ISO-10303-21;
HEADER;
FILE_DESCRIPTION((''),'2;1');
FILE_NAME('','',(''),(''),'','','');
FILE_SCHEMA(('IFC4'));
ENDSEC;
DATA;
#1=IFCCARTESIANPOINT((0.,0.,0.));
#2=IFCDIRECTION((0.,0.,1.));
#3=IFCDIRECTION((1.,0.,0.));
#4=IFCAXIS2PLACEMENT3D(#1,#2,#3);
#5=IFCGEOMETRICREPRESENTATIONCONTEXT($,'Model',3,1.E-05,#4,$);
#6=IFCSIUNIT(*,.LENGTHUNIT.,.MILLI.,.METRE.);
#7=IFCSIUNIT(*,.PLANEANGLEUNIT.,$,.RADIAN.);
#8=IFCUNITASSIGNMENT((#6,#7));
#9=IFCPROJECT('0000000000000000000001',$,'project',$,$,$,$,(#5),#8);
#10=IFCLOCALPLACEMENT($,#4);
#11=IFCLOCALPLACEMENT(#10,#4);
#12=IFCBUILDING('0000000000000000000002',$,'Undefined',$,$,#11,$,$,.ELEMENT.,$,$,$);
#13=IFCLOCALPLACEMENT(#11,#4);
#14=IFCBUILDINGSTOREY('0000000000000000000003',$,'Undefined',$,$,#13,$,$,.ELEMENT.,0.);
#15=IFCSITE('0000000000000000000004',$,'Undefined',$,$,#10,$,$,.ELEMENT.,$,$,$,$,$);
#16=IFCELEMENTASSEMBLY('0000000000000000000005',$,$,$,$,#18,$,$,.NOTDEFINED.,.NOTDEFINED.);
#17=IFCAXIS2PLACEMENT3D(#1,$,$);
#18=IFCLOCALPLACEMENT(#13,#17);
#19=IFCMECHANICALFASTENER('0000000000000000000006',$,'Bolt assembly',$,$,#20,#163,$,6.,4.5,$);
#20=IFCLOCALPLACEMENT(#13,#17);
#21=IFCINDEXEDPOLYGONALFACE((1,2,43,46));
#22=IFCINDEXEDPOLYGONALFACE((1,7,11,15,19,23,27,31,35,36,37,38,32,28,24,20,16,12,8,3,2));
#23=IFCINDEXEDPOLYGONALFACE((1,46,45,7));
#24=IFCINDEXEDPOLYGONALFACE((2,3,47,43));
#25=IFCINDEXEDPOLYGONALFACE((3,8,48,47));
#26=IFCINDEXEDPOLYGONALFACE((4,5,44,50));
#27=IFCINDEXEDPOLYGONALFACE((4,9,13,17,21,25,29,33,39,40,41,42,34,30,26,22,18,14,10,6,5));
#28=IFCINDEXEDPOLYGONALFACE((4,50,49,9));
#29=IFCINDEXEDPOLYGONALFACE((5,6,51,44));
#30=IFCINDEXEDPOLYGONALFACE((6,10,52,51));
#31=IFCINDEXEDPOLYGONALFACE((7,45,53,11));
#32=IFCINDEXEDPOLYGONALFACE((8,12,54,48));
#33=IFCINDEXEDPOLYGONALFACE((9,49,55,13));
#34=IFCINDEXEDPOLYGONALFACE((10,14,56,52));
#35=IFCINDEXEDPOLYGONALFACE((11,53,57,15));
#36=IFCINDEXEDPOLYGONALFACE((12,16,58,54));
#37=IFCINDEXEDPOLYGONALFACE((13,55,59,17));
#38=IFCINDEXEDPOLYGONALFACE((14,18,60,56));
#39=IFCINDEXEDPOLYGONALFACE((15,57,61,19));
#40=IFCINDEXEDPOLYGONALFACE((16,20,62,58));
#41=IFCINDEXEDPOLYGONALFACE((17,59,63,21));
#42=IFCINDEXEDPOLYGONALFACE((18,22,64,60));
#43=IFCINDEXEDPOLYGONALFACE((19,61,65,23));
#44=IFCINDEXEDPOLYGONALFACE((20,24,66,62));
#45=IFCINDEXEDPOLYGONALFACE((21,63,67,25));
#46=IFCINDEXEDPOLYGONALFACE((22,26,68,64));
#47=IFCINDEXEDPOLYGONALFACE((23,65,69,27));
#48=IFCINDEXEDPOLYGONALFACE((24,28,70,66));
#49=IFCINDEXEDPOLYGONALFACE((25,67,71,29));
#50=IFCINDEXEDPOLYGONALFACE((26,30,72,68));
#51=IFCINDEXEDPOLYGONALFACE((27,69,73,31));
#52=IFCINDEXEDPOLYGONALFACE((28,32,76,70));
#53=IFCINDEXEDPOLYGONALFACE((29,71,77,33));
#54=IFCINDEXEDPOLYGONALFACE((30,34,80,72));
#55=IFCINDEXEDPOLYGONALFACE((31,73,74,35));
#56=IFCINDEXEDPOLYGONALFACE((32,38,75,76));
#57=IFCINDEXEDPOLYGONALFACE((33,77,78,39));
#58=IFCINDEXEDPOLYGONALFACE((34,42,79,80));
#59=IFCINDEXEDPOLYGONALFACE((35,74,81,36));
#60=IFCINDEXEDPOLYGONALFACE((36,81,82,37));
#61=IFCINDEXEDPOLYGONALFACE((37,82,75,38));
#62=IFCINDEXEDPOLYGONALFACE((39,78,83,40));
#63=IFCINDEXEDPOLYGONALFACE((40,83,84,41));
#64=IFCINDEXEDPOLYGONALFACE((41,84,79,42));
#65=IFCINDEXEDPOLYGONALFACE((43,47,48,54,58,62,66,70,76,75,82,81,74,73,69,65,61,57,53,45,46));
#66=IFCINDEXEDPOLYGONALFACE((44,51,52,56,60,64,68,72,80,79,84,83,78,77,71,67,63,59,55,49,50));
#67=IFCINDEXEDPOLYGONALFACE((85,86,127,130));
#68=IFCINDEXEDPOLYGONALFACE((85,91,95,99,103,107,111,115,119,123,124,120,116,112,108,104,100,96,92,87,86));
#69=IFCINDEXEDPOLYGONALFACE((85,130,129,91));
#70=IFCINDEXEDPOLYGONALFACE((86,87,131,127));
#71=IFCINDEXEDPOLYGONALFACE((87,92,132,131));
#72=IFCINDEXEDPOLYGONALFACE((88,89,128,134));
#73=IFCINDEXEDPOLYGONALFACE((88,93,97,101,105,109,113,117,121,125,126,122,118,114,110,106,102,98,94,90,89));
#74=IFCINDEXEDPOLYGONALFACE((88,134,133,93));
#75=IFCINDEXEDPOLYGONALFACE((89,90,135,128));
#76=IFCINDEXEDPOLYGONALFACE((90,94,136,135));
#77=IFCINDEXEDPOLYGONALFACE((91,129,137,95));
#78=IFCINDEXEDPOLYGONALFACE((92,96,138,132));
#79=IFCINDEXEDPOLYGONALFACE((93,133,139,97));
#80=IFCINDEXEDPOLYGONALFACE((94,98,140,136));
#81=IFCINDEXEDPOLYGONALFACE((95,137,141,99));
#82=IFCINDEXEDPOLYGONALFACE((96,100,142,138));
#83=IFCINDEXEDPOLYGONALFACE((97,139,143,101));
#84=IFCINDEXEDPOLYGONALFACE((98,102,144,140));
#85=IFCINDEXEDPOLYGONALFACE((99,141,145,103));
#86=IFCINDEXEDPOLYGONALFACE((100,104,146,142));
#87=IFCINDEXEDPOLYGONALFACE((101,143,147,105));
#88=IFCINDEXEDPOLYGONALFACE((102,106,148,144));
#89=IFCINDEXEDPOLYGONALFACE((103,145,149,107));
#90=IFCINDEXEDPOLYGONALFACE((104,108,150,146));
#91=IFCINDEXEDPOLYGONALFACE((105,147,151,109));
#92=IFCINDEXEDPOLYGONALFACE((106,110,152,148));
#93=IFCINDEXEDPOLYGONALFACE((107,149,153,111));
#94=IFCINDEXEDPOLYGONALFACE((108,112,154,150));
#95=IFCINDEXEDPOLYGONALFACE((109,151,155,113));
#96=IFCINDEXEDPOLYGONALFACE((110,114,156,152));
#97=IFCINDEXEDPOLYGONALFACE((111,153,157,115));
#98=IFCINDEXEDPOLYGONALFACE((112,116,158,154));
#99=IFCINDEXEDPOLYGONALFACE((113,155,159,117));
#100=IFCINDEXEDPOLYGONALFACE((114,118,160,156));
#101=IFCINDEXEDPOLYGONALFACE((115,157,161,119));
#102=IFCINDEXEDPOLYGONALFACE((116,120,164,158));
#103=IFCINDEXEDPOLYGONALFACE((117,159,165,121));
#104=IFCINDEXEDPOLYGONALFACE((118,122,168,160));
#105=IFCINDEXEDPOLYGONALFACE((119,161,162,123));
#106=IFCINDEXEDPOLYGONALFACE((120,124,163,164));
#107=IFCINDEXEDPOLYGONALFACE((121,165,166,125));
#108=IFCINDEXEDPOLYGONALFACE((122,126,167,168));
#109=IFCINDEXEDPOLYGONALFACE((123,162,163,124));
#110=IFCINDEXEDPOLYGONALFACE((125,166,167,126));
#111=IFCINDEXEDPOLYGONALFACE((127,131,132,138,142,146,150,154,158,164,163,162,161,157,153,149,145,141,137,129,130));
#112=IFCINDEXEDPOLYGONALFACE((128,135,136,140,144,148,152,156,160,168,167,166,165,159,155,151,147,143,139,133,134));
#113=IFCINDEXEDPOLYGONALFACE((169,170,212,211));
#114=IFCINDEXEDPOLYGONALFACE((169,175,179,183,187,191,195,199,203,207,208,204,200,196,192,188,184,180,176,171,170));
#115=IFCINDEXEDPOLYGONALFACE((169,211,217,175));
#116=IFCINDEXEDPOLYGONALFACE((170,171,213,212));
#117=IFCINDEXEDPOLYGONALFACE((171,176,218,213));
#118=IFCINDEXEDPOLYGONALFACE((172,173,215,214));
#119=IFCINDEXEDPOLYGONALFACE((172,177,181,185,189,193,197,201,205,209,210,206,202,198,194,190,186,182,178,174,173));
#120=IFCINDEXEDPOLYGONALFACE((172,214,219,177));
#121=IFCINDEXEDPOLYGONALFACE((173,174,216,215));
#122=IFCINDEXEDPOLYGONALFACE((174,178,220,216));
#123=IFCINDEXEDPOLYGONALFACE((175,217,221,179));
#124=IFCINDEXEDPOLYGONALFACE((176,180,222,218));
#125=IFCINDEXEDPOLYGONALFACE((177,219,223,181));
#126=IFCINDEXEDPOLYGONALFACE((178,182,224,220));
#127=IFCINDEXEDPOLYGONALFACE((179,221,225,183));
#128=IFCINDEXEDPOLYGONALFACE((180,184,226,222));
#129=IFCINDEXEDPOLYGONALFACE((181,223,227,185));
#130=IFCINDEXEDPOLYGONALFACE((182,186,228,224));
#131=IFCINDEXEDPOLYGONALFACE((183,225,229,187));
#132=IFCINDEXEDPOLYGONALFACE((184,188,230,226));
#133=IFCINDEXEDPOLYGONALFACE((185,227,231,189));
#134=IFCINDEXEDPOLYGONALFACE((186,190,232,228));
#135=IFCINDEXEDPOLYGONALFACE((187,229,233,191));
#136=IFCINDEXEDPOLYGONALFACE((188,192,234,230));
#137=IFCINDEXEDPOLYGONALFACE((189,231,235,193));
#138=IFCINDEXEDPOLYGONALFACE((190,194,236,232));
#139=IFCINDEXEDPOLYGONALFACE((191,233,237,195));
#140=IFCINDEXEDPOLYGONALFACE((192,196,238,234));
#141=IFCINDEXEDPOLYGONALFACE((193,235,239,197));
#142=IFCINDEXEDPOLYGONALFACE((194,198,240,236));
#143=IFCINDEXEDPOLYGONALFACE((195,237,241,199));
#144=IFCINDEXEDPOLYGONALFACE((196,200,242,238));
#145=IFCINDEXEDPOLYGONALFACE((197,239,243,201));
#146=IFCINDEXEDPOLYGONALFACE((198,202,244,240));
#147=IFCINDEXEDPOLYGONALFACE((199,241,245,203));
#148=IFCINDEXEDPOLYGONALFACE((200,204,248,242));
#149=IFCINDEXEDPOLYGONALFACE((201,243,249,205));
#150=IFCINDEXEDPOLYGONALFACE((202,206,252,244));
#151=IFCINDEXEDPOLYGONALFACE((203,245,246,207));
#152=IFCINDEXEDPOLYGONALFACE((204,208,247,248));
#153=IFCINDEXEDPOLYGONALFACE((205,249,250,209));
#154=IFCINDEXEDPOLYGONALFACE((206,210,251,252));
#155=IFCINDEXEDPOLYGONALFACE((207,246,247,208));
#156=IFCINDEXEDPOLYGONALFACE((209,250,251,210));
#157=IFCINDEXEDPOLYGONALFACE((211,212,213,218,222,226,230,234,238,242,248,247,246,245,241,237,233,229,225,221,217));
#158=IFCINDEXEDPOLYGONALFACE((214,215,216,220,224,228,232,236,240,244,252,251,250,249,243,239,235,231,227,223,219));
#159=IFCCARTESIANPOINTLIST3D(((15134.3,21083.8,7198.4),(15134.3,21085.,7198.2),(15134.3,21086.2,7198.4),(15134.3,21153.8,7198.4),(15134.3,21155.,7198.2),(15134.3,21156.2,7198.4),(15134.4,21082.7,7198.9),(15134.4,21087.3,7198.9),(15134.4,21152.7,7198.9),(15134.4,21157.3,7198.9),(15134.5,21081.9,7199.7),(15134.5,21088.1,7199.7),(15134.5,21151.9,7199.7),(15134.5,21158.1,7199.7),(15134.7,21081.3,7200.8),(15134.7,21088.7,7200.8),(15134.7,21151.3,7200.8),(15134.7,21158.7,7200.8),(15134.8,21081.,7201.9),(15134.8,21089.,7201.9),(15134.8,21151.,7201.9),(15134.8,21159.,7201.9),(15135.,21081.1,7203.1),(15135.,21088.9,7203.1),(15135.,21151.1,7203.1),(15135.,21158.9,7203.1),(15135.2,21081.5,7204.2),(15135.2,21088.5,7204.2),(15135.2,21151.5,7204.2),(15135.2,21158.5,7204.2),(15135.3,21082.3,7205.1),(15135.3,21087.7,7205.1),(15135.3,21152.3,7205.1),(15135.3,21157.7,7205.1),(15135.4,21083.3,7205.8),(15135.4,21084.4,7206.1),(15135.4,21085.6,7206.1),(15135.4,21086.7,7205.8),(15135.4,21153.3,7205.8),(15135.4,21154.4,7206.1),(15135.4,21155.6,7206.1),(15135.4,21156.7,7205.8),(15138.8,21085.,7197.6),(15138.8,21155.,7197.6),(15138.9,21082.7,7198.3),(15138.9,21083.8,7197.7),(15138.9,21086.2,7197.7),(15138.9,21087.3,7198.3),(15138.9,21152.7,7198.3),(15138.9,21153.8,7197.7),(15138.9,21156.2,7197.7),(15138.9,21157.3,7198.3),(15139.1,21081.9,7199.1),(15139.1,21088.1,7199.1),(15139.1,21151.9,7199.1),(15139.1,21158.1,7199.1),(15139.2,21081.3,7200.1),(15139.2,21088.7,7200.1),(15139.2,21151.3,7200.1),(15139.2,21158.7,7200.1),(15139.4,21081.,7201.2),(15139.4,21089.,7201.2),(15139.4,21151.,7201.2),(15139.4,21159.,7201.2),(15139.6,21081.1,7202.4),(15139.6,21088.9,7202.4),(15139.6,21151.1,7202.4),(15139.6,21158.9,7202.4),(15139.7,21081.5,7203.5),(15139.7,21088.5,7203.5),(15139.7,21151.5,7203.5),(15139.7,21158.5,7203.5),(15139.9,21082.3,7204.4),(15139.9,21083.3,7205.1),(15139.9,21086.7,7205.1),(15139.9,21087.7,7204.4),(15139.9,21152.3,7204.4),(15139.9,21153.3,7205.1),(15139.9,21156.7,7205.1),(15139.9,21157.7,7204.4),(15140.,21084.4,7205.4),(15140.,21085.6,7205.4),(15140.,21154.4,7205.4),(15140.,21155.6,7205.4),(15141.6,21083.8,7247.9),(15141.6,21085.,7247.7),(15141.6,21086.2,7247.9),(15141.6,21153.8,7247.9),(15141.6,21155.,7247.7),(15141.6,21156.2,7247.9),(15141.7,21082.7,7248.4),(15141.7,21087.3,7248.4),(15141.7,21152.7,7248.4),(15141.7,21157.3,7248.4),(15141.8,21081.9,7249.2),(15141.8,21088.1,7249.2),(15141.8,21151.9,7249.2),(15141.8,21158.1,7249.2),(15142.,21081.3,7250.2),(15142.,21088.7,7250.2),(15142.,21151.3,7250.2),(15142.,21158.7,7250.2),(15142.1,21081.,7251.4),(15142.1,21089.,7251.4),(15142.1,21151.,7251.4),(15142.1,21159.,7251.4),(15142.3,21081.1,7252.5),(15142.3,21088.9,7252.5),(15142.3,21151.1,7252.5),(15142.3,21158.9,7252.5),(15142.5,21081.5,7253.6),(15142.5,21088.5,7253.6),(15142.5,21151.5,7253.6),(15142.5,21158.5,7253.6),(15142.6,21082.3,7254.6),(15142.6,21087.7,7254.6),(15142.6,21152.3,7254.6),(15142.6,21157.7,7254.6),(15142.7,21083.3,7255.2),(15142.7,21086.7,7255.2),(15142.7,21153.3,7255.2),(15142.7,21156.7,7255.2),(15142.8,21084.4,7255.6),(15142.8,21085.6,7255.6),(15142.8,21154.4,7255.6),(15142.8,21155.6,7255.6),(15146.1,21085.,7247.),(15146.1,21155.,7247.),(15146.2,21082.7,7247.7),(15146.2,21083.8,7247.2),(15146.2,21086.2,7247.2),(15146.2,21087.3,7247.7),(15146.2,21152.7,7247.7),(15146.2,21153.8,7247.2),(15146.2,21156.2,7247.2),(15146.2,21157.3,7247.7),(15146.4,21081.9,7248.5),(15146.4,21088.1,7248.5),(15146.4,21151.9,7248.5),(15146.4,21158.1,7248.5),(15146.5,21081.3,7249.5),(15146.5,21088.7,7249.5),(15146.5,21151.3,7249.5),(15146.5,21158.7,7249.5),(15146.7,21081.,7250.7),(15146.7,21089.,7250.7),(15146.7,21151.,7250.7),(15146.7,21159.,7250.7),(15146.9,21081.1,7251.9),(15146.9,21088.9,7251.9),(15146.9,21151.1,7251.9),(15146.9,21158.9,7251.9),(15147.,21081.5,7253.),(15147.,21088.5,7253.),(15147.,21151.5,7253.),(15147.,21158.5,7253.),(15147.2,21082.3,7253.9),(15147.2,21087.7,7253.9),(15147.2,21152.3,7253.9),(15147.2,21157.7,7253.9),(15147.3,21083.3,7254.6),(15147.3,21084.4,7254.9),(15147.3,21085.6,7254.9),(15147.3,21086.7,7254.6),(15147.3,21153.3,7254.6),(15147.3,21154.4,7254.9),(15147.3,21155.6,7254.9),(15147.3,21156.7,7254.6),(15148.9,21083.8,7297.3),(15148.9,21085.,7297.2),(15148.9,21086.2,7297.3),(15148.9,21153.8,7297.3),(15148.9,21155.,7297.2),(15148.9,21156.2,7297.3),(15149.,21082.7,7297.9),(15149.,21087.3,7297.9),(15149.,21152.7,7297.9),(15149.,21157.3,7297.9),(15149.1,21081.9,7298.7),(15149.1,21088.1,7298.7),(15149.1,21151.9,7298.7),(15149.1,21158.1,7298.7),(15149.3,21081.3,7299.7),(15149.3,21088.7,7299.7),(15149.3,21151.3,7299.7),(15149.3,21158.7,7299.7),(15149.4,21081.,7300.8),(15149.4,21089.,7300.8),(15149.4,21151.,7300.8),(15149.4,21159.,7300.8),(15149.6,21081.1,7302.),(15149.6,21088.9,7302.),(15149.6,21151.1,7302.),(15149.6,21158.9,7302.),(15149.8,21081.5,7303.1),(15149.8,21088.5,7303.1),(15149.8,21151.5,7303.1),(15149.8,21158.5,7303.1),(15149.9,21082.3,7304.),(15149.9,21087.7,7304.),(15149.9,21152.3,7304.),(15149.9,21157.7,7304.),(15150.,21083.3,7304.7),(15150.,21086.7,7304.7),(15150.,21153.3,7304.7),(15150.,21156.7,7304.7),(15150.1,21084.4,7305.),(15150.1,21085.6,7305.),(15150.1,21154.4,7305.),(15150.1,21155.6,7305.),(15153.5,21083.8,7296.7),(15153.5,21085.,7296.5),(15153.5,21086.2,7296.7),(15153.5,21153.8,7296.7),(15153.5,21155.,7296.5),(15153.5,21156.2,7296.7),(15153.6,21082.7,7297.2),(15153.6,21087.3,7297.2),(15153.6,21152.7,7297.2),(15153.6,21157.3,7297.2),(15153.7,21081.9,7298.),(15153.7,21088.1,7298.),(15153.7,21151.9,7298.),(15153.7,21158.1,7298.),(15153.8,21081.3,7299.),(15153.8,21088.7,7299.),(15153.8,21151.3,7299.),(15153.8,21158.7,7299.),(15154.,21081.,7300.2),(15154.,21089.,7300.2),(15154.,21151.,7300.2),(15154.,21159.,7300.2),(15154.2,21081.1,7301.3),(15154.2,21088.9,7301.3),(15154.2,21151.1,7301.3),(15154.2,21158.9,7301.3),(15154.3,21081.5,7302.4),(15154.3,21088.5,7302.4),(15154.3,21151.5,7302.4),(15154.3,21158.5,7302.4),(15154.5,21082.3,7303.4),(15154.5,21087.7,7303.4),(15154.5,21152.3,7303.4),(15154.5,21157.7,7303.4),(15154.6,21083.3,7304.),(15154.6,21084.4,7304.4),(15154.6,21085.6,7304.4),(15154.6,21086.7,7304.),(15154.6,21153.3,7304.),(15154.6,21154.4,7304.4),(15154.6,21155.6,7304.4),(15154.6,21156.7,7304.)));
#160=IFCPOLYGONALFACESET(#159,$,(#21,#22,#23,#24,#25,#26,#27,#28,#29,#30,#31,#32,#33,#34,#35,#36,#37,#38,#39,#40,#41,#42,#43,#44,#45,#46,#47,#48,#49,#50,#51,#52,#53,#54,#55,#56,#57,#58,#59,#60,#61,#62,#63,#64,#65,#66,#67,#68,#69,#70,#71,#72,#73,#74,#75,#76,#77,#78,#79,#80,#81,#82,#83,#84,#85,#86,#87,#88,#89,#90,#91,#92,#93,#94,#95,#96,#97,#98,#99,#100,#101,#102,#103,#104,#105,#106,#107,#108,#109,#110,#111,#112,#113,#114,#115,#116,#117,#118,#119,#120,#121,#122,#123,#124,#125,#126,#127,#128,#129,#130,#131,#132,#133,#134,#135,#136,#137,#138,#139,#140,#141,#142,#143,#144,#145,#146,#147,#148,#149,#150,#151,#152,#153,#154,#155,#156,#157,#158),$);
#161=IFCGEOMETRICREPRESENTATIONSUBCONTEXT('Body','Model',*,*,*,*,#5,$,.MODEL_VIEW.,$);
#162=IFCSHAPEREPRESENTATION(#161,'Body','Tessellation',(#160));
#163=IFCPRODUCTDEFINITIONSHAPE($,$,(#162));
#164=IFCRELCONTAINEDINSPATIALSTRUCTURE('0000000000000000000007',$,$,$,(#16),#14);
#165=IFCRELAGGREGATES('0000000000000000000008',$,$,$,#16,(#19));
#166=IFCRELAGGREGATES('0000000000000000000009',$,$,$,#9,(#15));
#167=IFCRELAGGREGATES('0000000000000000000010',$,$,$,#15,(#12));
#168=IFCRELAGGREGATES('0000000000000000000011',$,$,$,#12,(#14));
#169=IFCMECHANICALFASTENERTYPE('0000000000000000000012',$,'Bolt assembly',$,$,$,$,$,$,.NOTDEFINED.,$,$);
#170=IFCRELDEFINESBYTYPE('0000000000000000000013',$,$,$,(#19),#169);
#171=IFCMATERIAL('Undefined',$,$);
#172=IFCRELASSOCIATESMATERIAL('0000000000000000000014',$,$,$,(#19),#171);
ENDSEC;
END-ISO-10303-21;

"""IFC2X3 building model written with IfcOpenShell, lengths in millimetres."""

from ifc_helpers import new_model, si_unit, frame, origin_with_axes, origin_2d_with_axis, place, context, subcontext, project, spatial, circle, extrude, source, transform, mapped, material, type_object, element, aggregate, save


model = new_model("IFC2X3")

# Units and contexts
model_context = context("Model", 3, precision=1e-05, world=origin_with_axes())
body_context = subcontext(model_context, "Body", "Model", "MODEL_VIEW")
ifc_project = project(units=[si_unit("LENGTHUNIT", "METRE", prefix="MILLI"), si_unit("PLANEANGLEUNIT", "RADIAN")], contexts=[model_context])

# Site, building, storey
site_placement = place(None, origin_with_axes())
site = spatial("IfcSite", under=ifc_project, at=site_placement, Name="Undefined", CompositionType="ELEMENT")
building_placement = place(site_placement, origin_with_axes())
building = spatial("IfcBuilding", under=site, at=building_placement, Name="Undefined", CompositionType="ELEMENT")
storey_placement = place(building_placement, origin_with_axes())
storey = spatial("IfcBuildingStorey", under=building, at=storey_placement, Name="Undefined", CompositionType="ELEMENT", Elevation=0.0)

# Element assembly
assembly_1_placement = place(storey_placement, origin_with_axes())
assembly_1 = element("IfcElementAssembly", 1, at=assembly_1_placement, inside=storey, AssemblyPlace="NOTDEFINED", PredefinedType="NOTDEFINED")

# Mechanical fastener
ifc_material_1 = material(Name="Undefined")
mechanical_fastener_type = type_object("IfcMechanicalFastenerType", Name="Bolt assembly")
shared_shape_1 = source(origin_with_axes(), body_context, "Body", "SweptSolid", [
    extrude(circle(Radius=4.0, at=origin_2d_with_axis()), frame((0.0, 0.0, 0.0), z_axis=(0.0, 1.0, 0.0), x_axis=(1.0, 0.0, 0.0)), (0.0, 0.0, 1.0), 4.6),
])
mechanical_fastener_1_placement = place(assembly_1_placement, frame((15154.0, 21120.0, 7300.5), z_axis=(0.0, 1.0, 0.0), x_axis=(-0.146202, 0.0, -0.989255)))
mechanical_fastener_1 = element("IfcMechanicalFastener", 2, at=mechanical_fastener_1_placement, type_object=mechanical_fastener_type, material=ifc_material_1, Name="Bolt assembly", NominalDiameter=6.0, NominalLength=4.5, context=body_context, shape_type="MappedRepresentation", body=[
    mapped(shared_shape_1, transform((0.0, 0.0, 35.0))),
    mapped(shared_shape_1, transform((50.0, 0.0, 35.0))),
    mapped(shared_shape_1, transform((100.0, 0.0, 35.0))),
    mapped(shared_shape_1, transform((0.0, 0.0, -35.0))),
    mapped(shared_shape_1, transform((50.0, 0.0, -35.0))),
    mapped(shared_shape_1, transform((100.0, 0.0, -35.0))),
])

aggregate(assembly_1, [mechanical_fastener_1])

save(model, "model.ifc")
